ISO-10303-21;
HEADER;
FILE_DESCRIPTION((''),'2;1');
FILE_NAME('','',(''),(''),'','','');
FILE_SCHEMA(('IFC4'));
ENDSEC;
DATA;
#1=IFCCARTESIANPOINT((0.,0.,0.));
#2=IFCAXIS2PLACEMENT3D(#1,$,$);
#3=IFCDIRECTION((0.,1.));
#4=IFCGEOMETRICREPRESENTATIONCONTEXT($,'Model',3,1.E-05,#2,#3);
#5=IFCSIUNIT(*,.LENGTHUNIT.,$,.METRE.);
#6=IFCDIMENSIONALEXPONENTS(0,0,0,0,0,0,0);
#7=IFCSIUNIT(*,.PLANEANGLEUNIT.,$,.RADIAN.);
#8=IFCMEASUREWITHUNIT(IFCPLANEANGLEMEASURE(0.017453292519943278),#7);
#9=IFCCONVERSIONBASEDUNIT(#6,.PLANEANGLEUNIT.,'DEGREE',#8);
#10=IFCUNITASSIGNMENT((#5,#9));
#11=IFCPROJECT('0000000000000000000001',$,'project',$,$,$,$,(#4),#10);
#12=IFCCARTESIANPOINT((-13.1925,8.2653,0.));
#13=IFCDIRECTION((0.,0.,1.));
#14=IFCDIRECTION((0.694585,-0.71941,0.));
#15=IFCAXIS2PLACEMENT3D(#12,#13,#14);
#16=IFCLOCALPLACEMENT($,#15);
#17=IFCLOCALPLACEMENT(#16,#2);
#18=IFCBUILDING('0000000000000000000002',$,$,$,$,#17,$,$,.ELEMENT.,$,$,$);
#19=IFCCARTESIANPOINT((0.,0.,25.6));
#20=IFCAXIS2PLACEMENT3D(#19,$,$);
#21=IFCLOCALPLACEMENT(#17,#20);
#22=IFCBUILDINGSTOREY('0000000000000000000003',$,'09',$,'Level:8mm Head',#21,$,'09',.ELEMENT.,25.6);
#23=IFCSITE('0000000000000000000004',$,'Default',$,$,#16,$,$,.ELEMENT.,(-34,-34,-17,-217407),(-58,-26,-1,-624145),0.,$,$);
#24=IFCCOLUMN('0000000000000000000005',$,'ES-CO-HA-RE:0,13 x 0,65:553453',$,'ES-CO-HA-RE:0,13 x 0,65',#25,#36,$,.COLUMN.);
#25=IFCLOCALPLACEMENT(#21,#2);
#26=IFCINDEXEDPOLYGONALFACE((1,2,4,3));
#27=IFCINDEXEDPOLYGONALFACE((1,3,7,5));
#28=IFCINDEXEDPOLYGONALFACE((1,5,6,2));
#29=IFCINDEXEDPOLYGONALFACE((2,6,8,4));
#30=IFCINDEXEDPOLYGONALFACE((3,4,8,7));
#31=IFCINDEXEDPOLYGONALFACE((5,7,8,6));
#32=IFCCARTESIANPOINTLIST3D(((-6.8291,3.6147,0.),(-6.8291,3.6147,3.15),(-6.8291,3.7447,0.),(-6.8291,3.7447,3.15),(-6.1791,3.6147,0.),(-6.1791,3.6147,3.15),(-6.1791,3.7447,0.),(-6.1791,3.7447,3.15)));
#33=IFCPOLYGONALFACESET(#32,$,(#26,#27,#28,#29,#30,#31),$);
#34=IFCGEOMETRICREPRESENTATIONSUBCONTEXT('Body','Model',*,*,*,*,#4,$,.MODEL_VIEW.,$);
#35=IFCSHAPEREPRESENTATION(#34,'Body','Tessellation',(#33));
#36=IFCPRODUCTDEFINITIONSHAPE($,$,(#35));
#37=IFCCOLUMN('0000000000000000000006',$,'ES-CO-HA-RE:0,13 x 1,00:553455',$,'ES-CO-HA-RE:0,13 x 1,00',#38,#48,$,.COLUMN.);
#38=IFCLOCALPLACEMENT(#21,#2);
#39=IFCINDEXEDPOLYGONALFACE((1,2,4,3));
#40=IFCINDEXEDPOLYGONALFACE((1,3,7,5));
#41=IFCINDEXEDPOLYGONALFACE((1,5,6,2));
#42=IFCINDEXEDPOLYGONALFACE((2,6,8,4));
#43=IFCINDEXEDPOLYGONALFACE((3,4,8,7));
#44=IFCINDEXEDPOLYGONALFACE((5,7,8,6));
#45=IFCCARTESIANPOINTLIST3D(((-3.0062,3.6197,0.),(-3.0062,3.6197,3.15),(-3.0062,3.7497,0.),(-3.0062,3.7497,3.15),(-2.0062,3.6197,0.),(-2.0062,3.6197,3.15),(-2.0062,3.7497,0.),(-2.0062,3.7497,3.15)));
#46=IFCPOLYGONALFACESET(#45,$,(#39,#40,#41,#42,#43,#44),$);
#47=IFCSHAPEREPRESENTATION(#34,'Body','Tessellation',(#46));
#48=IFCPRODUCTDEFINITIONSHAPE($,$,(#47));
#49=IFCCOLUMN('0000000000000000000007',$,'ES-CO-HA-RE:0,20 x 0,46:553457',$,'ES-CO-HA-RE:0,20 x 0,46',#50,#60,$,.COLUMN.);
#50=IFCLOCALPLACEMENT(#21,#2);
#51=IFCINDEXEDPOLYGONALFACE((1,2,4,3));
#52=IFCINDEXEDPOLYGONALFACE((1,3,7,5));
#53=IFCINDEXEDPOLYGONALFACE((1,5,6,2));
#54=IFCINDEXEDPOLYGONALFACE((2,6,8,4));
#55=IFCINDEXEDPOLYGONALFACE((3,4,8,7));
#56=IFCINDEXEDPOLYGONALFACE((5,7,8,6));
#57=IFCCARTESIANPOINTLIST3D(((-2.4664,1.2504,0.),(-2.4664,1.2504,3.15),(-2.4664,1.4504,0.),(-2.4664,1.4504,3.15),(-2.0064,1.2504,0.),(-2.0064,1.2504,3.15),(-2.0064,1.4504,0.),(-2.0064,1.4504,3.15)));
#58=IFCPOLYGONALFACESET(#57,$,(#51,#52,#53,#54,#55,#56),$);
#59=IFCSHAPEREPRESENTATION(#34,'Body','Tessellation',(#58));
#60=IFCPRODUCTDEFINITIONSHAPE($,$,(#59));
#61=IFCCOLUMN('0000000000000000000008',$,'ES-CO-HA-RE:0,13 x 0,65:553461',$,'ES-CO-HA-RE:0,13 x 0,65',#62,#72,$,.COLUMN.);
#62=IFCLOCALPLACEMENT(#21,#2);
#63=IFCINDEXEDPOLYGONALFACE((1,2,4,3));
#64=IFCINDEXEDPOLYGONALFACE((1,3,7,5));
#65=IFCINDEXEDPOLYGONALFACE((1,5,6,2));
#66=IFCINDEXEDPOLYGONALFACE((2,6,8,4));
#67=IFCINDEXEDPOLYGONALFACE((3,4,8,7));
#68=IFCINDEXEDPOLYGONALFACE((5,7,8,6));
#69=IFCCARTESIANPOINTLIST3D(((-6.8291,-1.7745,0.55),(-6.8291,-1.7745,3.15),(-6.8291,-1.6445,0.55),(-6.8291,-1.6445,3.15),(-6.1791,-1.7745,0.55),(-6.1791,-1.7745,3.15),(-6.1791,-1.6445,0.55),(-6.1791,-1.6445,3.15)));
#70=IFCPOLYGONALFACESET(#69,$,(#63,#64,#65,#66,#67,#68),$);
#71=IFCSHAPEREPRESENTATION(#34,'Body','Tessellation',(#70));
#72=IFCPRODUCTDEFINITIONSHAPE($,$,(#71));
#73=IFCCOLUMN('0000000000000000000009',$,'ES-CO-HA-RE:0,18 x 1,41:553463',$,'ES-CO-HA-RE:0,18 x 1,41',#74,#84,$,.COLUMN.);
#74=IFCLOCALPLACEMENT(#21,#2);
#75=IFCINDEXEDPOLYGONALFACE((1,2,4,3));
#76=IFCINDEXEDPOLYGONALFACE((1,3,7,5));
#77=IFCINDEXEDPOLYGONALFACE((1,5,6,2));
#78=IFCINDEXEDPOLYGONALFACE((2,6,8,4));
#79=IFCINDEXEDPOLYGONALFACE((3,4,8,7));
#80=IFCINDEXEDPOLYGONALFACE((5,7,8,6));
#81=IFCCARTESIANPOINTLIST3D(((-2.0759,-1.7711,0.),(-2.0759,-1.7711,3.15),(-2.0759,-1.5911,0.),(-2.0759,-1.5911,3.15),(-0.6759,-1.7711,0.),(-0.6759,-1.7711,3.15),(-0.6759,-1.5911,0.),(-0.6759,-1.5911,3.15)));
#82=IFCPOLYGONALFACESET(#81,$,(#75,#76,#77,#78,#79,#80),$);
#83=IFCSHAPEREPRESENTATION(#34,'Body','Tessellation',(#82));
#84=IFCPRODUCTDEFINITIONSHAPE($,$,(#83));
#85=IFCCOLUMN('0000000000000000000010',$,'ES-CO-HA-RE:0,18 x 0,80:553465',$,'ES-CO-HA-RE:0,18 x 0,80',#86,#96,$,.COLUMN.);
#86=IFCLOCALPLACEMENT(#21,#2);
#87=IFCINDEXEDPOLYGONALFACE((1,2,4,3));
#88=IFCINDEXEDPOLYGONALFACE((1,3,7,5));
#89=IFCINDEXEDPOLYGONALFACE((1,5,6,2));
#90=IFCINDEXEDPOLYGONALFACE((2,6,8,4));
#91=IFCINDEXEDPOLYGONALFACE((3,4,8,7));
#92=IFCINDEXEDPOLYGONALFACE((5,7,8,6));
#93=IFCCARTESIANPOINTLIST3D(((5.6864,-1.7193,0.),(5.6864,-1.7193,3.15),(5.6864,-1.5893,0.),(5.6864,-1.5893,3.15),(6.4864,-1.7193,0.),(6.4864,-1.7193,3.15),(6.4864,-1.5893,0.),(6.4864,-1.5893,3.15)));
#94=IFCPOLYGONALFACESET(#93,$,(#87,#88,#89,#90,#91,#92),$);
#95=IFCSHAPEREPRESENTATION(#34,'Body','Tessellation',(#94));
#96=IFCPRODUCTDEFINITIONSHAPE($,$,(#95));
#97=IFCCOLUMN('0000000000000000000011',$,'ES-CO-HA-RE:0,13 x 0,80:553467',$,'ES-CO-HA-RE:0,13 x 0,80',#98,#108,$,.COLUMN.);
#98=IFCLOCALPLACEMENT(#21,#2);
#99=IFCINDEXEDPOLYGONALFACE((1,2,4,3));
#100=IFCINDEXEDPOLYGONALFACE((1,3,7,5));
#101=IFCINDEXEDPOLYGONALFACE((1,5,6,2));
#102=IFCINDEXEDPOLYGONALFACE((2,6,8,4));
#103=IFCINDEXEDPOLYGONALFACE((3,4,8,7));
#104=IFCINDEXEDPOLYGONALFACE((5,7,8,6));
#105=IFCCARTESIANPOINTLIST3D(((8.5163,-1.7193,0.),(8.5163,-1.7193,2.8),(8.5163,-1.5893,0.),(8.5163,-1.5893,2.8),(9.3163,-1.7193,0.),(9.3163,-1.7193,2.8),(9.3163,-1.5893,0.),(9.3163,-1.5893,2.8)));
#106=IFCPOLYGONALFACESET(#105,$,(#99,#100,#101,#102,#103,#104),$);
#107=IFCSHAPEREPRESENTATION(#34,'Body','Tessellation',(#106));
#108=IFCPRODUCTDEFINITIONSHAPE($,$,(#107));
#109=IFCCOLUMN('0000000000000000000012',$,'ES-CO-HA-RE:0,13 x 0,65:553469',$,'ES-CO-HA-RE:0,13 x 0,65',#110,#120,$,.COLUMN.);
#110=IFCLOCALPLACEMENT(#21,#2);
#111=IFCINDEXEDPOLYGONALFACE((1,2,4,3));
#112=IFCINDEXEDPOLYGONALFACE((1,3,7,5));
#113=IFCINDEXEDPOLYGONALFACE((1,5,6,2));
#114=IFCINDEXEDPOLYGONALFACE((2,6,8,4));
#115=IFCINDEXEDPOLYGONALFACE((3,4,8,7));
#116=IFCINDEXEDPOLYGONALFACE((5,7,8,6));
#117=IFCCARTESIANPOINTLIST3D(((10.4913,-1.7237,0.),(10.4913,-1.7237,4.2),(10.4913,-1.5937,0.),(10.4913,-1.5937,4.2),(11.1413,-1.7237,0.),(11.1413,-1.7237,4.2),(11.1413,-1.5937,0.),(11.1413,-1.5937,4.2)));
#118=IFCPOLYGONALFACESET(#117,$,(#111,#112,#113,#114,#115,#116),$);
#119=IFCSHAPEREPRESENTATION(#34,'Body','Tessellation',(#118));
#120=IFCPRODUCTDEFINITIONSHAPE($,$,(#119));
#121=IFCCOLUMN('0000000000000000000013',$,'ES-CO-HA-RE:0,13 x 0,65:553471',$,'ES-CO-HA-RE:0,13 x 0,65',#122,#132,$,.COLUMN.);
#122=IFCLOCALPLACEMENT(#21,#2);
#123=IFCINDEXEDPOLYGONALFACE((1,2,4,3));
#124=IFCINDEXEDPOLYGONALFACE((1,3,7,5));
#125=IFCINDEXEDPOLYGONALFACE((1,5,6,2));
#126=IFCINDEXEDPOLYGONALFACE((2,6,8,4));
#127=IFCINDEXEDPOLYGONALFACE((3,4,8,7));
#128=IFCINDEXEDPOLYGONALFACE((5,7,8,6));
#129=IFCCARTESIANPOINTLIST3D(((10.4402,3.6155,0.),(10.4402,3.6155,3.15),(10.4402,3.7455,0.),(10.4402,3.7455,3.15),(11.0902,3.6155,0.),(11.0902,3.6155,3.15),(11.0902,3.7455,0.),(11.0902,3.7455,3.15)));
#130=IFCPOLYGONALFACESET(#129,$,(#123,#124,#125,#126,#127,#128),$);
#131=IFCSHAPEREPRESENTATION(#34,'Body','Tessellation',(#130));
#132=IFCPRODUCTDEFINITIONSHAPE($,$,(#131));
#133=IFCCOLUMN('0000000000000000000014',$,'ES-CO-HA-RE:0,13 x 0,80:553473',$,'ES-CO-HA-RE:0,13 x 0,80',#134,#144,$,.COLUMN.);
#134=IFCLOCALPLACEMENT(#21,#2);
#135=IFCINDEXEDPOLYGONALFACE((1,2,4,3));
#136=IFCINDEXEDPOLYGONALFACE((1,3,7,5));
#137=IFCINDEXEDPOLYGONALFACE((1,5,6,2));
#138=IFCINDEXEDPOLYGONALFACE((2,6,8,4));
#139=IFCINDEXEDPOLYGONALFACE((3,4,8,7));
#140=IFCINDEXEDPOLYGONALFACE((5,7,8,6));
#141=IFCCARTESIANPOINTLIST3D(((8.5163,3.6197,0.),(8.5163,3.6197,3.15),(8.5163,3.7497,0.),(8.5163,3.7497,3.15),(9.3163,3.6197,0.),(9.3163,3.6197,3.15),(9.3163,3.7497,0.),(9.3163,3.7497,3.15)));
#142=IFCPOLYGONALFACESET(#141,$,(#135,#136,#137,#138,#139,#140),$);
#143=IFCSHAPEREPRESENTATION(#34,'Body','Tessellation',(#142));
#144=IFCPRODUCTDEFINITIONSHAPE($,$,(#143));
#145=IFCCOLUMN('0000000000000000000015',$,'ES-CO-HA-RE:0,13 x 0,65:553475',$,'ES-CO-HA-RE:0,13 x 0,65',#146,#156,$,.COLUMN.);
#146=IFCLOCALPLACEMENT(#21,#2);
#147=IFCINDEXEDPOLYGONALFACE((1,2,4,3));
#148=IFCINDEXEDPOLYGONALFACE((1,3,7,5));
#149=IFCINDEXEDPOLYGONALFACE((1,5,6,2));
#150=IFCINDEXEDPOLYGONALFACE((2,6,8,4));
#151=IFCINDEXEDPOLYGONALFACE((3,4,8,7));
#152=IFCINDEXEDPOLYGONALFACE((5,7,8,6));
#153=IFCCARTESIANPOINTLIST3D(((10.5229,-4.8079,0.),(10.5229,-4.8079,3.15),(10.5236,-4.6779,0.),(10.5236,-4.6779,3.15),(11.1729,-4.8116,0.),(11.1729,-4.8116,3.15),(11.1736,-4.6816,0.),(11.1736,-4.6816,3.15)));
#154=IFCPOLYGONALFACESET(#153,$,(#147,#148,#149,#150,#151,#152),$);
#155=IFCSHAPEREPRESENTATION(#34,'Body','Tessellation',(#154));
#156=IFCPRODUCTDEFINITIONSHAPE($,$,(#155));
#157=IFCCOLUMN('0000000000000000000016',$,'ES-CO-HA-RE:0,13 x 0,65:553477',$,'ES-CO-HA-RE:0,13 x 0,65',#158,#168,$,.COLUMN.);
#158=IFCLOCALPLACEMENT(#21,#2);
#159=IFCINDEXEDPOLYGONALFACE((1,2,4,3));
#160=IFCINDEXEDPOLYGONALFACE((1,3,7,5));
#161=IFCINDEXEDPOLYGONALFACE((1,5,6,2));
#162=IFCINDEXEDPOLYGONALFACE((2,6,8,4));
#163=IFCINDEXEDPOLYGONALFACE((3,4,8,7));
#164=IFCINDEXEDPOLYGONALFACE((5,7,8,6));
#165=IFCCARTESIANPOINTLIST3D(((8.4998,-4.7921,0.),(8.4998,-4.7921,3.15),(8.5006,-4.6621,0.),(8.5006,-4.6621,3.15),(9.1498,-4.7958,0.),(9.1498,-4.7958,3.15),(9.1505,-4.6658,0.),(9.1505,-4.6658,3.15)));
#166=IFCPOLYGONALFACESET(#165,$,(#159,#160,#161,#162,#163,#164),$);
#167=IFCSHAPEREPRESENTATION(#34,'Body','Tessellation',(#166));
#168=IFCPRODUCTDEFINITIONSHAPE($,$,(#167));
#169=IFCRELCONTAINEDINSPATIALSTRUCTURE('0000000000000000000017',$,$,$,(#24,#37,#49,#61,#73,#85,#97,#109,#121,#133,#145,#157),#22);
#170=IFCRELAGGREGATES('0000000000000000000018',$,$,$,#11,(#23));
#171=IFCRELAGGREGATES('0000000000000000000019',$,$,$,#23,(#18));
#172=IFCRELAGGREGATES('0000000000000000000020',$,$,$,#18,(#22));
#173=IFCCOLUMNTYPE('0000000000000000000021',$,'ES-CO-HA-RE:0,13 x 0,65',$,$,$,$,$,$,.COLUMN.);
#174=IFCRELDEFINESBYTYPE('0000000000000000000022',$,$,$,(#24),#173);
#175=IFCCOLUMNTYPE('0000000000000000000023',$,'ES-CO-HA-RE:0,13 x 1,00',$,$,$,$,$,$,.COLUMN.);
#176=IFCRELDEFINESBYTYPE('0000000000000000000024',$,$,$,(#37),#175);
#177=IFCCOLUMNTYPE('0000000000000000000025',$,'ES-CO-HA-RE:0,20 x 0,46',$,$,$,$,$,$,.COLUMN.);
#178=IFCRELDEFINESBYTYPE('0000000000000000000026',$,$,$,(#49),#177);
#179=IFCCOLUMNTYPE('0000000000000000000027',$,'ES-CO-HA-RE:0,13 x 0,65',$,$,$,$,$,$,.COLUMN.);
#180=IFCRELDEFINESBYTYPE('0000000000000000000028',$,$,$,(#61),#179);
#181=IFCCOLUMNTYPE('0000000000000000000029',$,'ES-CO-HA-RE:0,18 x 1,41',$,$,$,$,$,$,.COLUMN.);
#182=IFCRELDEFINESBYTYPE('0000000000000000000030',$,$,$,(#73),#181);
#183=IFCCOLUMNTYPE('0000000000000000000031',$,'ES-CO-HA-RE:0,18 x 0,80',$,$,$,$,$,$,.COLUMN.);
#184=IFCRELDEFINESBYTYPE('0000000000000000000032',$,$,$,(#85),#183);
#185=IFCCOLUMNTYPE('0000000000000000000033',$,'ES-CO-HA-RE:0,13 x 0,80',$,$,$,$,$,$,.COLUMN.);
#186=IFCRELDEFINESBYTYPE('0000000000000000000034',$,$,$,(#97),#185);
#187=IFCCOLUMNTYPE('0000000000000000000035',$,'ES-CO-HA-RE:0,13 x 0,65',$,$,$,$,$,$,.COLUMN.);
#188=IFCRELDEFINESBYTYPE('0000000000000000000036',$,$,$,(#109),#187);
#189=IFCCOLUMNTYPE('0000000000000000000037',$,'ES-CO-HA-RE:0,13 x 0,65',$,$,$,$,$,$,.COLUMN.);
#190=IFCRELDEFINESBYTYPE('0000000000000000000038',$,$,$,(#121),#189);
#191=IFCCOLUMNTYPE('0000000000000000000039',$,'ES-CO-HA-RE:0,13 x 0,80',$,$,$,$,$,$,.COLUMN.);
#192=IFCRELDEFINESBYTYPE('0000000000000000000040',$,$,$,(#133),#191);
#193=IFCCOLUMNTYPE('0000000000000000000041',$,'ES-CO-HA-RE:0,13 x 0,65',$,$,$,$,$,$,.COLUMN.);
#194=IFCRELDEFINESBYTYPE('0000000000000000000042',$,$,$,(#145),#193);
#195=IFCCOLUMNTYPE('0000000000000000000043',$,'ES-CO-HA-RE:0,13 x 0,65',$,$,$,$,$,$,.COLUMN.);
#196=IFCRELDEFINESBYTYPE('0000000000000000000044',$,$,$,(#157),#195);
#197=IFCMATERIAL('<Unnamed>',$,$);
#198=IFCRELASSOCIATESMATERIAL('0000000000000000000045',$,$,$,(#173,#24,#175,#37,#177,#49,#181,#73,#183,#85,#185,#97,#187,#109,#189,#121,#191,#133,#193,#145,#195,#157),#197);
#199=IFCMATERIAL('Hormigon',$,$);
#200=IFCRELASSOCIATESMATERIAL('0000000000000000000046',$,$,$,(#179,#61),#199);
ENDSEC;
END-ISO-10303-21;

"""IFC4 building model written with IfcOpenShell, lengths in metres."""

from ifc_helpers import new_model, entity, si_unit, converted_unit, direction, frame, origin, place, context, subcontext, project, spatial, indexed_curve, outline, extrude, source, transform, mapped, material, type_object, type_shapes, element, save


model = new_model("IFC4")

# Units and contexts
model_context = context("Model", 3, precision=1e-05, world=origin(), true_north=direction((0.0, 1.0)))
body_context = subcontext(model_context, "Body", "Model", "MODEL_VIEW")
ifc_project = project(units=[si_unit("LENGTHUNIT", "METRE"), converted_unit("PLANEANGLEUNIT", "DEGREE", entity("IfcPlaneAngleMeasure", 0.017453292519943278), si_unit("PLANEANGLEUNIT", "RADIAN"), dimensions=[0, 0, 0, 0, 0, 0, 0])], contexts=[model_context])

# Site, building, storey
site_placement = place(None, frame((-13.1925, 8.2653, 0.0), z_axis=(0.0, 0.0, 1.0), x_axis=(0.694585, -0.71941, 0.0)))
site = spatial("IfcSite", under=ifc_project, at=site_placement, Name="Default", CompositionType="ELEMENT", RefLatitude=(-34, -34, -17, -217407), RefLongitude=(-58, -26, -1, -624145), RefElevation=0.0)
building_placement = place(site_placement, origin())
building = spatial("IfcBuilding", under=site, at=building_placement, CompositionType="ELEMENT")
storey_placement = place(building_placement, frame((0.0, 0.0, 25.6)))
storey = spatial("IfcBuildingStorey", under=building, at=storey_placement, Name="09", ObjectType="Level:8mm Head", LongName="09", CompositionType="ELEMENT", Elevation=25.6)

# Columns
ifc_material_1 = material(Name="<Unnamed>")
column_type_1 = type_object("IfcColumnType", Name="ES-CO-HA-RE:0,13 x 0,65", PredefinedType="COLUMN", material=ifc_material_1)
shared_shape_1 = source(origin(), body_context, "Body", "SweptSolid", [
    extrude(outline(indexed_curve([(-0.325, -0.065), (0.325, -0.065), (0.325, 0.065), (-0.325, 0.065), (-0.325, -0.065)], self_intersect=False)), frame((-6.5041, 3.6797, 25.6), z_axis=(0.0, 0.0, 1.0), x_axis=(-1.0, 0.0, 0.0)), (0.0, 0.0, 1.0), 3.15),
])
type_shapes(column_type_1, [shared_shape_1])
column_1_placement = place(storey_placement, frame((0.0, 0.0, -25.6)))
element("IfcColumn", 1, at=column_1_placement, inside=storey, type_object=column_type_1, material=ifc_material_1, Name="ES-CO-HA-RE:0,13 x 0,65:553453", ObjectType="ES-CO-HA-RE:0,13 x 0,65", PredefinedType="COLUMN", context=body_context, shape_type="MappedRepresentation", body=[
    mapped(shared_shape_1, transform((0.0, 0.0, 0.0), scale=1.0)),
])
column_type_2 = type_object("IfcColumnType", Name="ES-CO-HA-RE:0,13 x 1,00", PredefinedType="COLUMN", material=ifc_material_1)
shared_shape_2 = source(origin(), body_context, "Body", "SweptSolid", [
    extrude(outline(indexed_curve([(-0.5, -0.065), (0.5, -0.065), (0.5, 0.065), (-0.5, 0.065), (-0.5, -0.065)], self_intersect=False)), frame((-2.5062, 3.6847, 25.6), z_axis=(0.0, 0.0, 1.0), x_axis=(-1.0, 0.0, 0.0)), (0.0, 0.0, 1.0), 3.15),
])
type_shapes(column_type_2, [shared_shape_2])
column_2_placement = place(storey_placement, frame((0.0, 0.0, -25.6)))
element("IfcColumn", 2, at=column_2_placement, inside=storey, type_object=column_type_2, material=ifc_material_1, Name="ES-CO-HA-RE:0,13 x 1,00:553455", ObjectType="ES-CO-HA-RE:0,13 x 1,00", PredefinedType="COLUMN", context=body_context, shape_type="MappedRepresentation", body=[
    mapped(shared_shape_2, transform((0.0, 0.0, 0.0), scale=1.0)),
])
column_type_3 = type_object("IfcColumnType", Name="ES-CO-HA-RE:0,20 x 0,46", PredefinedType="COLUMN", material=ifc_material_1)
shared_shape_3 = source(origin(), body_context, "Body", "SweptSolid", [
    extrude(outline(indexed_curve([(-0.23, -0.1), (0.23, -0.1), (0.23, 0.1), (-0.23, 0.1), (-0.23, -0.1)], self_intersect=False)), frame((-2.2364, 1.3504, 25.6), z_axis=(0.0, 0.0, 1.0), x_axis=(-1.0, 0.0, 0.0)), (0.0, 0.0, 1.0), 3.15),
])
type_shapes(column_type_3, [shared_shape_3])
column_3_placement = place(storey_placement, frame((0.0, 0.0, -25.6)))
element("IfcColumn", 3, at=column_3_placement, inside=storey, type_object=column_type_3, material=ifc_material_1, Name="ES-CO-HA-RE:0,20 x 0,46:553457", ObjectType="ES-CO-HA-RE:0,20 x 0,46", PredefinedType="COLUMN", context=body_context, shape_type="MappedRepresentation", body=[
    mapped(shared_shape_3, transform((0.0, 0.0, 0.0), scale=1.0)),
])
ifc_material_2 = material(Name="Hormigon")
column_type_4 = type_object("IfcColumnType", Name="ES-CO-HA-RE:0,13 x 0,65", PredefinedType="COLUMN", material=ifc_material_2)
shared_shape_4 = source(origin(), body_context, "Body", "SweptSolid", [
    extrude(outline(indexed_curve([(-0.325, -0.065), (0.325, -0.065), (0.325, 0.065), (-0.325, 0.065), (-0.325, -0.065)], self_intersect=False)), frame((-6.5041, -1.7095, 26.15), z_axis=(0.0, 0.0, 1.0), x_axis=(-1.0, 0.0, 0.0)), (0.0, 0.0, 1.0), 2.6),
])
type_shapes(column_type_4, [shared_shape_4])
column_4_placement = place(storey_placement, frame((0.0, 0.0, -25.6)))
element("IfcColumn", 4, at=column_4_placement, inside=storey, type_object=column_type_4, material=ifc_material_2, Name="ES-CO-HA-RE:0,13 x 0,65:553461", ObjectType="ES-CO-HA-RE:0,13 x 0,65", PredefinedType="COLUMN", context=body_context, shape_type="MappedRepresentation", body=[
    mapped(shared_shape_4, transform((0.0, 0.0, 0.0), scale=1.0)),
])
column_type_5 = type_object("IfcColumnType", Name="ES-CO-HA-RE:0,18 x 1,41", PredefinedType="COLUMN", material=ifc_material_1)
shared_shape_5 = source(origin(), body_context, "Body", "SweptSolid", [
    extrude(outline(indexed_curve([(-0.7, -0.09), (0.7, -0.09), (0.7, 0.09), (-0.7, 0.09), (-0.7, -0.09)], self_intersect=False)), frame((-1.3759, -1.6811, 25.6), z_axis=(0.0, 0.0, 1.0), x_axis=(-1.0, 0.0, 0.0)), (0.0, 0.0, 1.0), 3.15),
])
type_shapes(column_type_5, [shared_shape_5])
column_5_placement = place(storey_placement, frame((0.0, 0.0, -25.6)))
element("IfcColumn", 5, at=column_5_placement, inside=storey, type_object=column_type_5, material=ifc_material_1, Name="ES-CO-HA-RE:0,18 x 1,41:553463", ObjectType="ES-CO-HA-RE:0,18 x 1,41", PredefinedType="COLUMN", context=body_context, shape_type="MappedRepresentation", body=[
    mapped(shared_shape_5, transform((0.0, 0.0, 0.0), scale=1.0)),
])
column_type_6 = type_object("IfcColumnType", Name="ES-CO-HA-RE:0,18 x 0,80", PredefinedType="COLUMN", material=ifc_material_1)
shared_shape_6 = source(origin(), body_context, "Body", "SweptSolid", [
    extrude(outline(indexed_curve([(-0.4, -0.065), (0.4, -0.065), (0.4, 0.065), (-0.4, 0.065), (-0.4, -0.065)], self_intersect=False)), frame((6.0864, -1.6543, 25.6), z_axis=(0.0, 0.0, 1.0), x_axis=(-1.0, 0.0, 0.0)), (0.0, 0.0, 1.0), 3.15),
])
type_shapes(column_type_6, [shared_shape_6])
column_6_placement = place(storey_placement, frame((0.0, 0.0, -25.6)))
element("IfcColumn", 6, at=column_6_placement, inside=storey, type_object=column_type_6, material=ifc_material_1, Name="ES-CO-HA-RE:0,18 x 0,80:553465", ObjectType="ES-CO-HA-RE:0,18 x 0,80", PredefinedType="COLUMN", context=body_context, shape_type="MappedRepresentation", body=[
    mapped(shared_shape_6, transform((0.0, 0.0, 0.0), scale=1.0)),
])
column_type_7 = type_object("IfcColumnType", Name="ES-CO-HA-RE:0,13 x 0,80", PredefinedType="COLUMN", material=ifc_material_1)
shared_shape_7 = source(origin(), body_context, "Body", "SweptSolid", [
    extrude(outline(indexed_curve([(-0.4, -0.065), (0.4, -0.065), (0.4, 0.065), (-0.4, 0.065), (-0.4, -0.065)], self_intersect=False)), frame((8.9163, -1.6543, 25.6), z_axis=(0.0, 0.0, 1.0), x_axis=(-1.0, 0.0, 0.0)), (0.0, 0.0, 1.0), 2.8),
])
type_shapes(column_type_7, [shared_shape_7])
column_7_placement = place(storey_placement, frame((0.0, 0.0, -25.6)))
element("IfcColumn", 7, at=column_7_placement, inside=storey, type_object=column_type_7, material=ifc_material_1, Name="ES-CO-HA-RE:0,13 x 0,80:553467", ObjectType="ES-CO-HA-RE:0,13 x 0,80", PredefinedType="COLUMN", context=body_context, shape_type="MappedRepresentation", body=[
    mapped(shared_shape_7, transform((0.0, 0.0, 0.0), scale=1.0)),
])
column_type_8 = type_object("IfcColumnType", Name="ES-CO-HA-RE:0,13 x 0,65", PredefinedType="COLUMN", material=ifc_material_1)
shared_shape_8 = source(origin(), body_context, "Body", "SweptSolid", [
    extrude(outline(indexed_curve([(-0.325, -0.065), (0.325, -0.065), (0.325, 0.065), (-0.325, 0.065), (-0.325, -0.065)], self_intersect=False)), frame((10.8163, -1.6587, 25.6), z_axis=(0.0, 0.0, 1.0), x_axis=(-1.0, 0.0, 0.0)), (0.0, 0.0, 1.0), 4.2),
])
type_shapes(column_type_8, [shared_shape_8])
column_8_placement = place(storey_placement, frame((0.0, 0.0, -25.6)))
element("IfcColumn", 8, at=column_8_placement, inside=storey, type_object=column_type_8, material=ifc_material_1, Name="ES-CO-HA-RE:0,13 x 0,65:553469", ObjectType="ES-CO-HA-RE:0,13 x 0,65", PredefinedType="COLUMN", context=body_context, shape_type="MappedRepresentation", body=[
    mapped(shared_shape_8, transform((0.0, 0.0, 0.0), scale=1.0)),
])
column_type_9 = type_object("IfcColumnType", Name="ES-CO-HA-RE:0,13 x 0,65", PredefinedType="COLUMN", material=ifc_material_1)
shared_shape_9 = source(origin(), body_context, "Body", "SweptSolid", [
    extrude(outline(indexed_curve([(-0.325, -0.065), (0.325, -0.065), (0.325, 0.065), (-0.325, 0.065), (-0.325, -0.065)], self_intersect=False)), frame((10.7652, 3.6805, 25.6), z_axis=(0.0, 0.0, 1.0), x_axis=(-1.0, 0.0, 0.0)), (0.0, 0.0, 1.0), 3.15),
])
type_shapes(column_type_9, [shared_shape_9])
column_9_placement = place(storey_placement, frame((0.0, 0.0, -25.6)))
element("IfcColumn", 9, at=column_9_placement, inside=storey, type_object=column_type_9, material=ifc_material_1, Name="ES-CO-HA-RE:0,13 x 0,65:553471", ObjectType="ES-CO-HA-RE:0,13 x 0,65", PredefinedType="COLUMN", context=body_context, shape_type="MappedRepresentation", body=[
    mapped(shared_shape_9, transform((0.0, 0.0, 0.0), scale=1.0)),
])
column_type_10 = type_object("IfcColumnType", Name="ES-CO-HA-RE:0,13 x 0,80", PredefinedType="COLUMN", material=ifc_material_1)
shared_shape_10 = source(origin(), body_context, "Body", "SweptSolid", [
    extrude(outline(indexed_curve([(-0.4, -0.065), (0.4, -0.065), (0.4, 0.065), (-0.4, 0.065), (-0.4, -0.065)], self_intersect=False)), frame((8.9163, 3.6847, 25.6), z_axis=(0.0, 0.0, 1.0), x_axis=(-1.0, 0.0, 0.0)), (0.0, 0.0, 1.0), 3.15),
])
type_shapes(column_type_10, [shared_shape_10])
column_10_placement = place(storey_placement, frame((0.0, 0.0, -25.6)))
element("IfcColumn", 10, at=column_10_placement, inside=storey, type_object=column_type_10, material=ifc_material_1, Name="ES-CO-HA-RE:0,13 x 0,80:553473", ObjectType="ES-CO-HA-RE:0,13 x 0,80", PredefinedType="COLUMN", context=body_context, shape_type="MappedRepresentation", body=[
    mapped(shared_shape_10, transform((0.0, 0.0, 0.0), scale=1.0)),
])
column_type_11 = type_object("IfcColumnType", Name="ES-CO-HA-RE:0,13 x 0,65", PredefinedType="COLUMN", material=ifc_material_1)
shared_shape_11 = source(origin(), body_context, "Body", "SweptSolid", [
    extrude(outline(indexed_curve([(-0.325, -0.065), (0.325, -0.065), (0.325, 0.065), (-0.325, 0.065), (-0.325, -0.065)], self_intersect=False)), frame((10.8483, -4.7447, 25.6), z_axis=(0.0, 0.0, 1.0), x_axis=(-0.999984, 0.005619, 0.0)), (0.0, 0.0, 1.0), 3.15),
])
type_shapes(column_type_11, [shared_shape_11])
column_11_placement = place(storey_placement, frame((0.0, 0.0, -25.6)))
element("IfcColumn", 11, at=column_11_placement, inside=storey, type_object=column_type_11, material=ifc_material_1, Name="ES-CO-HA-RE:0,13 x 0,65:553475", ObjectType="ES-CO-HA-RE:0,13 x 0,65", PredefinedType="COLUMN", context=body_context, shape_type="MappedRepresentation", body=[
    mapped(shared_shape_11, transform((0.0, 0.0, 0.0), scale=1.0)),
])
column_type_12 = type_object("IfcColumnType", Name="ES-CO-HA-RE:0,13 x 0,65", PredefinedType="COLUMN", material=ifc_material_1)
shared_shape_12 = source(origin(), body_context, "Body", "SweptSolid", [
    extrude(outline(indexed_curve([(-0.325, -0.065), (0.325, -0.065), (0.325, 0.065), (-0.325, 0.065), (-0.325, -0.065)], self_intersect=False)), frame((8.8252, -4.7289, 25.6), z_axis=(0.0, 0.0, 1.0), x_axis=(-0.999984, 0.005619, 0.0)), (0.0, 0.0, 1.0), 3.15),
])
type_shapes(column_type_12, [shared_shape_12])
column_12_placement = place(storey_placement, frame((0.0, 0.0, -25.6)))
element("IfcColumn", 12, at=column_12_placement, inside=storey, type_object=column_type_12, material=ifc_material_1, Name="ES-CO-HA-RE:0,13 x 0,65:553477", ObjectType="ES-CO-HA-RE:0,13 x 0,65", PredefinedType="COLUMN", context=body_context, shape_type="MappedRepresentation", body=[
    mapped(shared_shape_12, transform((0.0, 0.0, 0.0), scale=1.0)),
])

save(model, "model.ifc")
